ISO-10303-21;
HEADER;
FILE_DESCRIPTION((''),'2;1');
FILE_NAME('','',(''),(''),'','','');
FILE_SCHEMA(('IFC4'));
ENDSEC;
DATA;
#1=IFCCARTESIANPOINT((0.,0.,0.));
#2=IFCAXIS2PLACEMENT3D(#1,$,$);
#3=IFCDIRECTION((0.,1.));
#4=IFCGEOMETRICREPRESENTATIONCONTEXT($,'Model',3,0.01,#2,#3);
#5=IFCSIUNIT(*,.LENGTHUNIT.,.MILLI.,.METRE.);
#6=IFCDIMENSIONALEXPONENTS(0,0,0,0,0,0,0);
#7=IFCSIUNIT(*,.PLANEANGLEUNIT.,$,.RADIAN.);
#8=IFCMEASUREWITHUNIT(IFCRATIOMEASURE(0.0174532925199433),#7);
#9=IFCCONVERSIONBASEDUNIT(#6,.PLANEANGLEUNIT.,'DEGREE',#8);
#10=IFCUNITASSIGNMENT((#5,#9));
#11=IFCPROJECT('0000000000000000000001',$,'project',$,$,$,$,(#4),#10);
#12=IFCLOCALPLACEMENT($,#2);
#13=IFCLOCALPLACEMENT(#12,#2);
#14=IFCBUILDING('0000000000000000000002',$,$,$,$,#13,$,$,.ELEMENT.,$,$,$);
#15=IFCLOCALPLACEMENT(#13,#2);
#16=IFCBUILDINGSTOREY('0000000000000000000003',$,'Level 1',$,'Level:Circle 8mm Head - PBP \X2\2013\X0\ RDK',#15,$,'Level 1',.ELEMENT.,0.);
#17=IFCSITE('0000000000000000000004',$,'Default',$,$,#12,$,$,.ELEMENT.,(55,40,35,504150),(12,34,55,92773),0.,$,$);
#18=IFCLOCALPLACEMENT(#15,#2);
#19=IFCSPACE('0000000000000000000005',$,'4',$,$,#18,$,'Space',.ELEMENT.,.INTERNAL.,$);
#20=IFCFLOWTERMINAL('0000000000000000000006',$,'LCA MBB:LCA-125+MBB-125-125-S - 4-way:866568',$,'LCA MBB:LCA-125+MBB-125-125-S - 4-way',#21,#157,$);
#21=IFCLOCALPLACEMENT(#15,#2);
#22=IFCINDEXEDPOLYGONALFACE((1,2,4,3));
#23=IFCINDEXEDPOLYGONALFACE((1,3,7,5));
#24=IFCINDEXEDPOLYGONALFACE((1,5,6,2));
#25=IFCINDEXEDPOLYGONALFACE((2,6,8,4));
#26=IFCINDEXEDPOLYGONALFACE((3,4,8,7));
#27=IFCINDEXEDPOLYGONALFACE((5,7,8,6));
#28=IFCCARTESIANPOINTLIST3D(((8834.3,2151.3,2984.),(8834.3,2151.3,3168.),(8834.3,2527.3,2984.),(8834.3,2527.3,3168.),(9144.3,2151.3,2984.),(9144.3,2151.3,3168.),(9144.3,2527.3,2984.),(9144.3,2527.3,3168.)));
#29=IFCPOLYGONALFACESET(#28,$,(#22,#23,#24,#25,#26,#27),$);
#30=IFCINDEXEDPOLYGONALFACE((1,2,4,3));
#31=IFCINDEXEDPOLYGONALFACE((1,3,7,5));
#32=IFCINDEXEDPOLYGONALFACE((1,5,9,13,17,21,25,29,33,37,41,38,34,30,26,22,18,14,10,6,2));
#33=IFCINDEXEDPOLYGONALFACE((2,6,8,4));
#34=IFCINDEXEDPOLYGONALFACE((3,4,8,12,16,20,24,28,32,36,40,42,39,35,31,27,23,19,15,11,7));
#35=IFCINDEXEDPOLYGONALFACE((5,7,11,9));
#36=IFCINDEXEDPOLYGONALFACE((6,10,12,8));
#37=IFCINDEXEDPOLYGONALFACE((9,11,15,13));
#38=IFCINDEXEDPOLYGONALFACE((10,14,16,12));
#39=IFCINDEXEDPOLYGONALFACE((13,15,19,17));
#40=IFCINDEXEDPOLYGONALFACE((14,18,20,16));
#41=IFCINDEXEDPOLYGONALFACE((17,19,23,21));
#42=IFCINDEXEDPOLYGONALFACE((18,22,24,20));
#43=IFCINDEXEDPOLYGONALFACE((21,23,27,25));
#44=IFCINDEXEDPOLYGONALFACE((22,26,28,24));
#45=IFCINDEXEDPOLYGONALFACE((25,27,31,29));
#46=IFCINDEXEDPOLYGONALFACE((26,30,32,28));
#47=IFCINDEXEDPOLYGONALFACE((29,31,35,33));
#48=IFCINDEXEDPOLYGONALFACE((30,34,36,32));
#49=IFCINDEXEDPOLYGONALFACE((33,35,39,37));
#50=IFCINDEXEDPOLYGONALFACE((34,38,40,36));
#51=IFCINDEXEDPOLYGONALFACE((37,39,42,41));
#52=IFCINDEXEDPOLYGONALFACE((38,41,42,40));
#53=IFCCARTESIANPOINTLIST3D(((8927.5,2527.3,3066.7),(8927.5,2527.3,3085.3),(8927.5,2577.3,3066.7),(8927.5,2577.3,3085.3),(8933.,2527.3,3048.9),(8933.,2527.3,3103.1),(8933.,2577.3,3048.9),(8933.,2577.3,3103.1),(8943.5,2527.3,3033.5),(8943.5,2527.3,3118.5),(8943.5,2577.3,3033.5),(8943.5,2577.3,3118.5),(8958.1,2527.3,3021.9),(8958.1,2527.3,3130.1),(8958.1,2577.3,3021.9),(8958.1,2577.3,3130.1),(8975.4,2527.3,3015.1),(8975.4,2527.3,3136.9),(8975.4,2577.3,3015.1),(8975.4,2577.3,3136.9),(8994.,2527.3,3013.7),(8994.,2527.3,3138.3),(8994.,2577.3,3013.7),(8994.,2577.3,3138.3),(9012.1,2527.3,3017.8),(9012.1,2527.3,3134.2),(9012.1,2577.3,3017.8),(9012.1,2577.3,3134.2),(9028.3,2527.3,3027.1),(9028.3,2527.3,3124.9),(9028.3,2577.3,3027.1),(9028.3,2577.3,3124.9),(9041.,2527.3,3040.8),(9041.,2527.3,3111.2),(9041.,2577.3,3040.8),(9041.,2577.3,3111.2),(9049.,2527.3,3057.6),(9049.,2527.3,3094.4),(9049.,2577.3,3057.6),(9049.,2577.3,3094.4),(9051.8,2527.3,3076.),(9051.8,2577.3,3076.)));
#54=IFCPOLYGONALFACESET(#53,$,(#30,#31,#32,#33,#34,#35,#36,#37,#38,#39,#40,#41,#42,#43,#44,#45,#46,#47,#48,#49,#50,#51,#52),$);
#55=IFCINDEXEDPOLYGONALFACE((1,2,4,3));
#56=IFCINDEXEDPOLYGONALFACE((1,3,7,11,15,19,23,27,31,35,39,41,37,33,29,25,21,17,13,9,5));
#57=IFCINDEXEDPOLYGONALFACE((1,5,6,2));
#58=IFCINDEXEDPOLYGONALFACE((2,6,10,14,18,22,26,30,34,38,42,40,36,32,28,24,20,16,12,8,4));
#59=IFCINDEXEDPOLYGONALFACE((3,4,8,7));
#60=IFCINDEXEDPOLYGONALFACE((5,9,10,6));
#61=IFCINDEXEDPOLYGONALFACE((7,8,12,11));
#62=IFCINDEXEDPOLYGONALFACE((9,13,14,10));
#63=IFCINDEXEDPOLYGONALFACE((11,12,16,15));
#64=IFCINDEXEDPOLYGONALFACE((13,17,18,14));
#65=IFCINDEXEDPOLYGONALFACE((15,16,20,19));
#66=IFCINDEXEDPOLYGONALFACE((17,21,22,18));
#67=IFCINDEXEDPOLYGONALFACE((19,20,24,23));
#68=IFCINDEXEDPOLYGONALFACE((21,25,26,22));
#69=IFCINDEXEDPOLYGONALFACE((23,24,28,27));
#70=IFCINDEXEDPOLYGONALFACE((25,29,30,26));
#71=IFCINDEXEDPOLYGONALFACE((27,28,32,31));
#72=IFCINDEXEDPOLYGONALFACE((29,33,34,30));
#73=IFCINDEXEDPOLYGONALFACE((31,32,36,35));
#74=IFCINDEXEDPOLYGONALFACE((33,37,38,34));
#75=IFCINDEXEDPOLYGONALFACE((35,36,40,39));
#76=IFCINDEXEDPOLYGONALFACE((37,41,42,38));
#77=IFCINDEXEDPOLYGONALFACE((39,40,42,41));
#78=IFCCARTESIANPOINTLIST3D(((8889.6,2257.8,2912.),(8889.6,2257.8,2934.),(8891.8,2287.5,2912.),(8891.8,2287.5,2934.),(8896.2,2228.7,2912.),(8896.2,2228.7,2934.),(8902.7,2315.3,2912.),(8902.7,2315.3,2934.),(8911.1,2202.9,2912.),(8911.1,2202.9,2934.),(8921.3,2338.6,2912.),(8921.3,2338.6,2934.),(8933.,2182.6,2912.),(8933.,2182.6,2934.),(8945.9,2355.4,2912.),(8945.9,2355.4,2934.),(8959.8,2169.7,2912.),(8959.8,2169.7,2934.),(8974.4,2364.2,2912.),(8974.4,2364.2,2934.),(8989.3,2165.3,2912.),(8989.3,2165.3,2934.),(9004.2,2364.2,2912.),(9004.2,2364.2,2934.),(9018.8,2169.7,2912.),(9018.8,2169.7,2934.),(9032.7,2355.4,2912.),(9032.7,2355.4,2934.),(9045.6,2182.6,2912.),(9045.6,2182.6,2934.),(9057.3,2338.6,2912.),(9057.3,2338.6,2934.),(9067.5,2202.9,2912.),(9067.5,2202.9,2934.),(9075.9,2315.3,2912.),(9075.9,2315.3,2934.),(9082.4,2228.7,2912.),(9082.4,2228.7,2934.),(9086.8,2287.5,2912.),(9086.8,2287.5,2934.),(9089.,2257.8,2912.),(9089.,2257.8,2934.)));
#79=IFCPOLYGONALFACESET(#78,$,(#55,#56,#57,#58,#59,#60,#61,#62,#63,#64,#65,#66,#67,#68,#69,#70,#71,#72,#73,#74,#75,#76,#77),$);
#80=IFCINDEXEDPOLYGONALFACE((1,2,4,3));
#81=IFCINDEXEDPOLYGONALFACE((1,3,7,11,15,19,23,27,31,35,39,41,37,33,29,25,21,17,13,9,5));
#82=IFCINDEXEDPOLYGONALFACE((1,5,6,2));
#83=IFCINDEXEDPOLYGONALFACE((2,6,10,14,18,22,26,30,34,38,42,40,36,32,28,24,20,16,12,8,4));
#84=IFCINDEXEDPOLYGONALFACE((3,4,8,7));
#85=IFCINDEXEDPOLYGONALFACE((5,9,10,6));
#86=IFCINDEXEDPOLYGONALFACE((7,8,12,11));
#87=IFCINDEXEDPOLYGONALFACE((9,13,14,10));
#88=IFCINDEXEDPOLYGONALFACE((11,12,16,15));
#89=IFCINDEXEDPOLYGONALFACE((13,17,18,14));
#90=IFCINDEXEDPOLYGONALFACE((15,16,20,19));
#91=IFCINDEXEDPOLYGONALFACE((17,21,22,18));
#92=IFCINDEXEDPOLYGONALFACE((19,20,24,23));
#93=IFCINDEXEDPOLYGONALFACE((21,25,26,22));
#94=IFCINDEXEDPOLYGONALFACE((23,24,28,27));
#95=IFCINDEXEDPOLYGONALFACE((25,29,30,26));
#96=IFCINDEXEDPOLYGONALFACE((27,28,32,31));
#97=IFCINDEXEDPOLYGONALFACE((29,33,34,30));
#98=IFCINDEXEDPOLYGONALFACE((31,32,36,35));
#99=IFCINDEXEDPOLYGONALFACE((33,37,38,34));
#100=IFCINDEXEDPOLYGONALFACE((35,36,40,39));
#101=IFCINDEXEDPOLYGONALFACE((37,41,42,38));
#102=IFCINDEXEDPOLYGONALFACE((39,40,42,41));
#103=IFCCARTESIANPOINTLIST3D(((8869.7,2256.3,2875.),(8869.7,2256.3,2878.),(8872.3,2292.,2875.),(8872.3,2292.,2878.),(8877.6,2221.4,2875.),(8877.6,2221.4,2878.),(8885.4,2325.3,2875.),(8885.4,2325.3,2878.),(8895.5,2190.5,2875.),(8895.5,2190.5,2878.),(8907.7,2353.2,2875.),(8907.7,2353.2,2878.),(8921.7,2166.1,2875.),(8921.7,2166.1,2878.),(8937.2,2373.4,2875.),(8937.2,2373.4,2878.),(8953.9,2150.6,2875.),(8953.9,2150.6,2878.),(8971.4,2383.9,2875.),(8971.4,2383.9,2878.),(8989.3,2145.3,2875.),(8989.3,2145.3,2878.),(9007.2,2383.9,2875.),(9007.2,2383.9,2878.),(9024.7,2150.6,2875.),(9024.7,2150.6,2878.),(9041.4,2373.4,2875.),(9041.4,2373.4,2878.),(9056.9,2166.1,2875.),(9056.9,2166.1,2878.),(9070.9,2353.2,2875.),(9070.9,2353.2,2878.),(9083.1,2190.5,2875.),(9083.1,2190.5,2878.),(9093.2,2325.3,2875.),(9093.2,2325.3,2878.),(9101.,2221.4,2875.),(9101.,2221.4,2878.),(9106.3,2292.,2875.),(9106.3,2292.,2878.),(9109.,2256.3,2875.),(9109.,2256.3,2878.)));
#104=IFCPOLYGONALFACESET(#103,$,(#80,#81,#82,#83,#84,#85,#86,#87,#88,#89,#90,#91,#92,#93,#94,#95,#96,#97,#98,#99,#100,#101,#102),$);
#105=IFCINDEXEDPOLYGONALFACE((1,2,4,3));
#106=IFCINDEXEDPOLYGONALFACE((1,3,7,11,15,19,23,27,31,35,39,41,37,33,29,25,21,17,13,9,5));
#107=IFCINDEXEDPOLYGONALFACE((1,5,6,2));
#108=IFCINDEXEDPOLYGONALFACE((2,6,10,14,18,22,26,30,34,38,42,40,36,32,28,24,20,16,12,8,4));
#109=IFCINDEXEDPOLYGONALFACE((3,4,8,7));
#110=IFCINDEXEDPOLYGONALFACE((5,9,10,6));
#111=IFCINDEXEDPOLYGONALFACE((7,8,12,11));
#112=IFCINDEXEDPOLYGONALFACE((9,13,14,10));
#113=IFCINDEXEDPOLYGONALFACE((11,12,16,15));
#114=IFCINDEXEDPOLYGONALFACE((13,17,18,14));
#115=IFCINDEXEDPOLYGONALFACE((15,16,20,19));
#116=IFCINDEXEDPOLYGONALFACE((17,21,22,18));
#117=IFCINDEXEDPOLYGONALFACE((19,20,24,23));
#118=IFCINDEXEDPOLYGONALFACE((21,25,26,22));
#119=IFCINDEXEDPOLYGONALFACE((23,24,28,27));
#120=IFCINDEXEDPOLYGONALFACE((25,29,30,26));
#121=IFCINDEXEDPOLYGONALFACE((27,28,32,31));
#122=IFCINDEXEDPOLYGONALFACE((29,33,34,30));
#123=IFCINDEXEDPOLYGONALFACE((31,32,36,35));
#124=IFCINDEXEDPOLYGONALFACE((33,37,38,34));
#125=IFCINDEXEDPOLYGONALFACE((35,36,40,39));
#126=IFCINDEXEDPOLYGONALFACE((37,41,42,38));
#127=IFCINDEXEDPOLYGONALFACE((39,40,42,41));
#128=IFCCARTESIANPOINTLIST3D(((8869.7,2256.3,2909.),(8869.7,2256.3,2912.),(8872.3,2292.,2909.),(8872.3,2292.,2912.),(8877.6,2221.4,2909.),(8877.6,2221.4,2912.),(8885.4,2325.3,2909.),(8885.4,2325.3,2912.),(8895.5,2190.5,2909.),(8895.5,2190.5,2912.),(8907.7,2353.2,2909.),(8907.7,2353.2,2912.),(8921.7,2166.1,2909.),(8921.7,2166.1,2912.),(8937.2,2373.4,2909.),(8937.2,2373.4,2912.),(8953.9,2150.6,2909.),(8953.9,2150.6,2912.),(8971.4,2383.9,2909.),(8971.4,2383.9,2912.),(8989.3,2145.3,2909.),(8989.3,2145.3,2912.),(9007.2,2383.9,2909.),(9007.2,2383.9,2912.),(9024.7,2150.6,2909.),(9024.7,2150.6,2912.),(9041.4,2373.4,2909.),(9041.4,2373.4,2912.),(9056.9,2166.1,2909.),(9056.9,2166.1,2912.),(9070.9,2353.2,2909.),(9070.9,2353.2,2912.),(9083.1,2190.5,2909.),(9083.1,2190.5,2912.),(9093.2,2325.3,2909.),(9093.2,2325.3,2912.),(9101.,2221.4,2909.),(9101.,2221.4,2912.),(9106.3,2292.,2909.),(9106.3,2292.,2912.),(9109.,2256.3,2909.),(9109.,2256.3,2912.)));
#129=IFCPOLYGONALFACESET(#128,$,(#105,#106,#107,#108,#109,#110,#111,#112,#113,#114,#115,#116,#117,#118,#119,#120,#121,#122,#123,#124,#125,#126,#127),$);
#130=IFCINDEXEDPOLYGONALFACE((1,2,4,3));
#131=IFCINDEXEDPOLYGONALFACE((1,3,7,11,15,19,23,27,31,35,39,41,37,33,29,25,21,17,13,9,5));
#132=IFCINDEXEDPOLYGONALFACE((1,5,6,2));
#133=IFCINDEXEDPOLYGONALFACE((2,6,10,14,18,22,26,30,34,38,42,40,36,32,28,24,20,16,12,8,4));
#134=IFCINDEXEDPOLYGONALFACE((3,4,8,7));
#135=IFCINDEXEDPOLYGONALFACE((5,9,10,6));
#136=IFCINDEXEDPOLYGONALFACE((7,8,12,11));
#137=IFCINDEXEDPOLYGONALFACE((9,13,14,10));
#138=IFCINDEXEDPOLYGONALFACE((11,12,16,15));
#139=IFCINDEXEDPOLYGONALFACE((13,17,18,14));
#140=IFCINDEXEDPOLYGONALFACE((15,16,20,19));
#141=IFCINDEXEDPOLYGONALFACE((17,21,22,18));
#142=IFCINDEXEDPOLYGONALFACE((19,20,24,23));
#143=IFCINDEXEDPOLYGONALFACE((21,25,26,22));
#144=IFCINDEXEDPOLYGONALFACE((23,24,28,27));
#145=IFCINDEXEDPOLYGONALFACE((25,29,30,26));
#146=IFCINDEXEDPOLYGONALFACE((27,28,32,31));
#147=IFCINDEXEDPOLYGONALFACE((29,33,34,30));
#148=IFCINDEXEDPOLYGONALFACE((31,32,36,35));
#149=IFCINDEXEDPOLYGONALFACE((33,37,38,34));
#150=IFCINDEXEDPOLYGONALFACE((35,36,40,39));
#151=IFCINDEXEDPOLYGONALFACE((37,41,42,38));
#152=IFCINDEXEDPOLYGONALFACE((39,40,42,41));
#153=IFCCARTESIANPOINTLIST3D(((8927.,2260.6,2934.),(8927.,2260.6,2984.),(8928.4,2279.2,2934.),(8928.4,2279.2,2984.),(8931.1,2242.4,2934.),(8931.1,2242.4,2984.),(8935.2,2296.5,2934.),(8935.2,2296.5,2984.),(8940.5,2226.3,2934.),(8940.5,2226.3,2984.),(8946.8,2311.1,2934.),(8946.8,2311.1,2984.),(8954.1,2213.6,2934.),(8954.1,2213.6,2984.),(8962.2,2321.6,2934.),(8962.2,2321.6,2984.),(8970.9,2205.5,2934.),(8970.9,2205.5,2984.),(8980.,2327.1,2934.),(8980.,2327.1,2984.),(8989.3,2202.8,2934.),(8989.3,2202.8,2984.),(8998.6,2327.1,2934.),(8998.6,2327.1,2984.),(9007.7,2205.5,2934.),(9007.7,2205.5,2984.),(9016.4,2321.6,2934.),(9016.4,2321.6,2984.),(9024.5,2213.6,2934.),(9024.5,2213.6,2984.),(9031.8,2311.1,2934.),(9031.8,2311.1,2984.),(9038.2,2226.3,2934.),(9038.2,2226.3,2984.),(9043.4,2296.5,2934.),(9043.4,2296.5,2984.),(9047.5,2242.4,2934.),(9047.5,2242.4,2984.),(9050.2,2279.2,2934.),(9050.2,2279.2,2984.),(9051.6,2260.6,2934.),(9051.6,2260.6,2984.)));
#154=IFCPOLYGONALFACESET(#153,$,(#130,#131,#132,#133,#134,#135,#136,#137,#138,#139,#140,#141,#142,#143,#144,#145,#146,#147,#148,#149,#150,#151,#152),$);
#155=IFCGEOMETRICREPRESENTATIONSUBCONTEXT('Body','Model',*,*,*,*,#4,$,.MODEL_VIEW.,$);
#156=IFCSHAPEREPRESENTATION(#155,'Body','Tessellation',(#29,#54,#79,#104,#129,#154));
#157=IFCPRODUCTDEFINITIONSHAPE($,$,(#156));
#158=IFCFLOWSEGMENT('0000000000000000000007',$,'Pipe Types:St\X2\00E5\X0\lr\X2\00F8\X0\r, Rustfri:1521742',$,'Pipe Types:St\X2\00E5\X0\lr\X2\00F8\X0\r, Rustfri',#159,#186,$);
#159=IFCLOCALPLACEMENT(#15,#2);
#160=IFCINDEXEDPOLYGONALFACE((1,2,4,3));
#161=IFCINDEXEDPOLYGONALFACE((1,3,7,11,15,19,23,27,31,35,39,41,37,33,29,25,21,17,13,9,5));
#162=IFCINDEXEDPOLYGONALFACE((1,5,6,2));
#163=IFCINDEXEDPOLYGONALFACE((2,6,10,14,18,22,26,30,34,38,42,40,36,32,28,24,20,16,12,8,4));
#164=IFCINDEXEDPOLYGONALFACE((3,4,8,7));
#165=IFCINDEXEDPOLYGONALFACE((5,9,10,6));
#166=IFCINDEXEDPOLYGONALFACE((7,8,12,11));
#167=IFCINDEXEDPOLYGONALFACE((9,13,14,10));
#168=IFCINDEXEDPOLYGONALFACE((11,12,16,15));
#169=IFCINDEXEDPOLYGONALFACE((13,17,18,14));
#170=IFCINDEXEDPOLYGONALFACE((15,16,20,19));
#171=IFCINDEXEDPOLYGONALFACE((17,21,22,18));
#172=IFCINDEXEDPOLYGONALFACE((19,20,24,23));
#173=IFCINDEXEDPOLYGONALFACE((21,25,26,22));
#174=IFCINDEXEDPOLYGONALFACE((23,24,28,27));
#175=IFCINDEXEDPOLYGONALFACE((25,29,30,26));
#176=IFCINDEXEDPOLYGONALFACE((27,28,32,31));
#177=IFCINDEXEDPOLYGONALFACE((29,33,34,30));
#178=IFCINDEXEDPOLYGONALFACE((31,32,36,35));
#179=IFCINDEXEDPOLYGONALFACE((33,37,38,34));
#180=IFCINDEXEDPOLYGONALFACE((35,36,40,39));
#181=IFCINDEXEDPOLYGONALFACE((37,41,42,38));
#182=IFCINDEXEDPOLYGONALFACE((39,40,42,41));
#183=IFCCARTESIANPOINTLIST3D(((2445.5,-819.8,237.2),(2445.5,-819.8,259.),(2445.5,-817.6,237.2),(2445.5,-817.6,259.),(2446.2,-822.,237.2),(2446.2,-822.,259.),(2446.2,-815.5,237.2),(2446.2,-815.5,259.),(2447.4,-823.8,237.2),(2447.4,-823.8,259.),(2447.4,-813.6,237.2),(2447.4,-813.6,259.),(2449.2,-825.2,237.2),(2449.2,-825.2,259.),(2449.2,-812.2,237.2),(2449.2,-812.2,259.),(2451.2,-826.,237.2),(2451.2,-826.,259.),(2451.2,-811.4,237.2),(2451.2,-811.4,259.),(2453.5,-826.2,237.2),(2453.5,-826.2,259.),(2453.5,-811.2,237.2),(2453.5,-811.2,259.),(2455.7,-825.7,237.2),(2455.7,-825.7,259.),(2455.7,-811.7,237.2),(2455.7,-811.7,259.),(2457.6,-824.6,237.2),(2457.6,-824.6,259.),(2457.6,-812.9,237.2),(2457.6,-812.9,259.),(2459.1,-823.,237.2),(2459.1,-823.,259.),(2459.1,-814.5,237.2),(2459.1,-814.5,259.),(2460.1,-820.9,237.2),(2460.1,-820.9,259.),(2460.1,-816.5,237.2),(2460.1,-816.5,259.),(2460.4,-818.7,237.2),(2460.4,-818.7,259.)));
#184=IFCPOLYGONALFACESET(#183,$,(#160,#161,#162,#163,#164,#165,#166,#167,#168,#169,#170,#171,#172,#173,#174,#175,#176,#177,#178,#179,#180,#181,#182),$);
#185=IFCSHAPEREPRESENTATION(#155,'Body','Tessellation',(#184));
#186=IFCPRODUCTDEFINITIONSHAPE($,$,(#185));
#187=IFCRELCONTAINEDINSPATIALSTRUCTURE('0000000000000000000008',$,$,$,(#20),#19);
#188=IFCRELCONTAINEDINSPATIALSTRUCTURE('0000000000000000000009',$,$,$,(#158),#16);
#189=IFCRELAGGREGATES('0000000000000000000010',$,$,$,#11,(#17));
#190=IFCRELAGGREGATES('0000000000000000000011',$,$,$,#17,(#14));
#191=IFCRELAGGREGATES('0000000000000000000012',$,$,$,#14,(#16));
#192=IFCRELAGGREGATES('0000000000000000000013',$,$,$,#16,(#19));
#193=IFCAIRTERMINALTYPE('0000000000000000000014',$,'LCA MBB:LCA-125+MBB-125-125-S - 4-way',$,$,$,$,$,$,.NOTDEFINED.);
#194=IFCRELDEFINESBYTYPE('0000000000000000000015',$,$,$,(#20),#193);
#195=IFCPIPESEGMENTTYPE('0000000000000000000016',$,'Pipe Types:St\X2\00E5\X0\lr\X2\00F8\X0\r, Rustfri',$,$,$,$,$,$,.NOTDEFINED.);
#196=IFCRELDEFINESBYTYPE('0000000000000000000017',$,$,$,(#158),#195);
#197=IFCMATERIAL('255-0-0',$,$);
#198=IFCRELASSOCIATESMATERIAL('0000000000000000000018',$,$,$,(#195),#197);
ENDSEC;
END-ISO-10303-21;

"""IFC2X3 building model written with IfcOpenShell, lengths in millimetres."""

from ifc_helpers import new_model, entity, si_unit, converted_unit, direction, frame, frame_2d, origin, origin_2d_with_axis, place, context, subcontext, project, spatial, rectangle, circle, extrude, source, transform, mapped, material, type_object, type_shapes, element, save


model = new_model("IFC2X3")

# Units and contexts
model_context = context("Model", 3, precision=0.01, world=origin(), true_north=direction((0.0, 1.0)))
body_context = subcontext(model_context, "Body", "Model", "MODEL_VIEW")
ifc_project = project(units=[si_unit("LENGTHUNIT", "METRE", prefix="MILLI"), converted_unit("PLANEANGLEUNIT", "DEGREE", entity("IfcRatioMeasure", 0.0174532925199433), si_unit("PLANEANGLEUNIT", "RADIAN"), dimensions=[0, 0, 0, 0, 0, 0, 0])], contexts=[model_context])

# Site, building, storey
site_placement = place(None, origin())
site = spatial("IfcSite", under=ifc_project, at=site_placement, Name="Default", CompositionType="ELEMENT", RefLatitude=(55, 40, 35, 504150), RefLongitude=(12, 34, 55, 92773), RefElevation=0.0)
building_placement = place(site_placement, origin())
building = spatial("IfcBuilding", under=site, at=building_placement, CompositionType="ELEMENT")
storey_placement = place(building_placement, origin())
storey = spatial("IfcBuildingStorey", under=building, at=storey_placement, Name="Level 1", ObjectType="Level:Circle 8mm Head - PBP – RDK", LongName="Level 1", CompositionType="ELEMENT", Elevation=0.0)

# Shared definitions
air_terminal_type_1 = type_object("IfcAirTerminalType", Name="LCA MBB:LCA-125+MBB-125-125-S - 4-way", PredefinedType="NOTDEFINED")
shared_shape_1 = source(origin(), body_context, "Body", "SweptSolid", [
    extrude(rectangle(XDim=310.0, YDim=376.0, at=origin_2d_with_axis()), frame((-74.0, 0.0, 72.0), z_axis=(0.0, 0.0, 1.0), x_axis=(0.0, -1.0, 0.0)), (0.0, 0.0, 1.0), 184.0),
    extrude(circle(Radius=62.5, at=frame_2d((0.0, 0.0), x_axis=(1.0, 0.0))), frame((-312.0, 0.0, 164.0), z_axis=(1.0, 0.0, 0.0), x_axis=(0.0, 1.0, 0.0)), (0.0, 0.0, 1.0), 50.0),
    extrude(circle(Radius=100.0, at=frame_2d((0.0, 0.0), x_axis=(1.0, 0.0))), origin(), (0.0, 0.0, 1.0), 22.0),
    extrude(circle(Radius=120.0, at=frame_2d((0.0, 0.0), x_axis=(1.0, 0.0))), frame((0.0, 0.0, -37.0)), (0.0, 0.0, 1.0), 3.0),
    extrude(circle(Radius=120.0, at=frame_2d((0.0, 0.0), x_axis=(1.0, 0.0))), frame((0.0, 0.0, -3.0)), (0.0, 0.0, 1.0), 3.0),
    extrude(circle(Radius=62.5, at=frame_2d((0.0, 0.0), x_axis=(1.0, 0.0))), frame((0.0, 0.0, 22.0)), (0.0, 0.0, 1.0), 50.0),
])
type_shapes(air_terminal_type_1, [shared_shape_1])

# Shared definitions
space_1_placement = place(storey_placement, origin())
space_1 = spatial("IfcSpace", under=storey, at=space_1_placement, Name="4", LongName="Space", CompositionType="ELEMENT", InteriorOrExteriorSpace="INTERNAL")

# Flow terminal
flow_terminal_1_placement = place(space_1_placement, frame((8989.3, 2265.3, 2912.0), z_axis=(0.0, 0.0, 1.0), x_axis=(0.0, -1.0, 0.0)))
element("IfcFlowTerminal", 1, at=flow_terminal_1_placement, inside=space_1, type_object=air_terminal_type_1, Name="LCA MBB:LCA-125+MBB-125-125-S - 4-way:866568", ObjectType="LCA MBB:LCA-125+MBB-125-125-S - 4-way", context=body_context, shape_type="MappedRepresentation", body=[
    mapped(shared_shape_1, transform((0.0, 0.0, 0.0), scale=1.0)),
])

# Flow segment
ifc_material_1 = material(Name="255-0-0")
pipe_segment_type = type_object("IfcPipeSegmentType", Name="Pipe Types:Stålrør, Rustfri", PredefinedType="NOTDEFINED", material=ifc_material_1)
flow_segment_1_placement = place(storey_placement, origin())
element("IfcFlowSegment", 2, at=flow_segment_1_placement, inside=storey, type_object=pipe_segment_type, Name="Pipe Types:Stålrør, Rustfri:1521742", ObjectType="Pipe Types:Stålrør, Rustfri", context=body_context, shape_type="SweptSolid", body=[
    extrude(circle(Radius=7.5, at=frame_2d((0.0, 0.0), x_axis=(1.0, 0.0))), frame((2452.9, -818.7, 237.2)), (0.0, 0.0, 1.0), 21.8),
])

save(model, "model.ifc")
